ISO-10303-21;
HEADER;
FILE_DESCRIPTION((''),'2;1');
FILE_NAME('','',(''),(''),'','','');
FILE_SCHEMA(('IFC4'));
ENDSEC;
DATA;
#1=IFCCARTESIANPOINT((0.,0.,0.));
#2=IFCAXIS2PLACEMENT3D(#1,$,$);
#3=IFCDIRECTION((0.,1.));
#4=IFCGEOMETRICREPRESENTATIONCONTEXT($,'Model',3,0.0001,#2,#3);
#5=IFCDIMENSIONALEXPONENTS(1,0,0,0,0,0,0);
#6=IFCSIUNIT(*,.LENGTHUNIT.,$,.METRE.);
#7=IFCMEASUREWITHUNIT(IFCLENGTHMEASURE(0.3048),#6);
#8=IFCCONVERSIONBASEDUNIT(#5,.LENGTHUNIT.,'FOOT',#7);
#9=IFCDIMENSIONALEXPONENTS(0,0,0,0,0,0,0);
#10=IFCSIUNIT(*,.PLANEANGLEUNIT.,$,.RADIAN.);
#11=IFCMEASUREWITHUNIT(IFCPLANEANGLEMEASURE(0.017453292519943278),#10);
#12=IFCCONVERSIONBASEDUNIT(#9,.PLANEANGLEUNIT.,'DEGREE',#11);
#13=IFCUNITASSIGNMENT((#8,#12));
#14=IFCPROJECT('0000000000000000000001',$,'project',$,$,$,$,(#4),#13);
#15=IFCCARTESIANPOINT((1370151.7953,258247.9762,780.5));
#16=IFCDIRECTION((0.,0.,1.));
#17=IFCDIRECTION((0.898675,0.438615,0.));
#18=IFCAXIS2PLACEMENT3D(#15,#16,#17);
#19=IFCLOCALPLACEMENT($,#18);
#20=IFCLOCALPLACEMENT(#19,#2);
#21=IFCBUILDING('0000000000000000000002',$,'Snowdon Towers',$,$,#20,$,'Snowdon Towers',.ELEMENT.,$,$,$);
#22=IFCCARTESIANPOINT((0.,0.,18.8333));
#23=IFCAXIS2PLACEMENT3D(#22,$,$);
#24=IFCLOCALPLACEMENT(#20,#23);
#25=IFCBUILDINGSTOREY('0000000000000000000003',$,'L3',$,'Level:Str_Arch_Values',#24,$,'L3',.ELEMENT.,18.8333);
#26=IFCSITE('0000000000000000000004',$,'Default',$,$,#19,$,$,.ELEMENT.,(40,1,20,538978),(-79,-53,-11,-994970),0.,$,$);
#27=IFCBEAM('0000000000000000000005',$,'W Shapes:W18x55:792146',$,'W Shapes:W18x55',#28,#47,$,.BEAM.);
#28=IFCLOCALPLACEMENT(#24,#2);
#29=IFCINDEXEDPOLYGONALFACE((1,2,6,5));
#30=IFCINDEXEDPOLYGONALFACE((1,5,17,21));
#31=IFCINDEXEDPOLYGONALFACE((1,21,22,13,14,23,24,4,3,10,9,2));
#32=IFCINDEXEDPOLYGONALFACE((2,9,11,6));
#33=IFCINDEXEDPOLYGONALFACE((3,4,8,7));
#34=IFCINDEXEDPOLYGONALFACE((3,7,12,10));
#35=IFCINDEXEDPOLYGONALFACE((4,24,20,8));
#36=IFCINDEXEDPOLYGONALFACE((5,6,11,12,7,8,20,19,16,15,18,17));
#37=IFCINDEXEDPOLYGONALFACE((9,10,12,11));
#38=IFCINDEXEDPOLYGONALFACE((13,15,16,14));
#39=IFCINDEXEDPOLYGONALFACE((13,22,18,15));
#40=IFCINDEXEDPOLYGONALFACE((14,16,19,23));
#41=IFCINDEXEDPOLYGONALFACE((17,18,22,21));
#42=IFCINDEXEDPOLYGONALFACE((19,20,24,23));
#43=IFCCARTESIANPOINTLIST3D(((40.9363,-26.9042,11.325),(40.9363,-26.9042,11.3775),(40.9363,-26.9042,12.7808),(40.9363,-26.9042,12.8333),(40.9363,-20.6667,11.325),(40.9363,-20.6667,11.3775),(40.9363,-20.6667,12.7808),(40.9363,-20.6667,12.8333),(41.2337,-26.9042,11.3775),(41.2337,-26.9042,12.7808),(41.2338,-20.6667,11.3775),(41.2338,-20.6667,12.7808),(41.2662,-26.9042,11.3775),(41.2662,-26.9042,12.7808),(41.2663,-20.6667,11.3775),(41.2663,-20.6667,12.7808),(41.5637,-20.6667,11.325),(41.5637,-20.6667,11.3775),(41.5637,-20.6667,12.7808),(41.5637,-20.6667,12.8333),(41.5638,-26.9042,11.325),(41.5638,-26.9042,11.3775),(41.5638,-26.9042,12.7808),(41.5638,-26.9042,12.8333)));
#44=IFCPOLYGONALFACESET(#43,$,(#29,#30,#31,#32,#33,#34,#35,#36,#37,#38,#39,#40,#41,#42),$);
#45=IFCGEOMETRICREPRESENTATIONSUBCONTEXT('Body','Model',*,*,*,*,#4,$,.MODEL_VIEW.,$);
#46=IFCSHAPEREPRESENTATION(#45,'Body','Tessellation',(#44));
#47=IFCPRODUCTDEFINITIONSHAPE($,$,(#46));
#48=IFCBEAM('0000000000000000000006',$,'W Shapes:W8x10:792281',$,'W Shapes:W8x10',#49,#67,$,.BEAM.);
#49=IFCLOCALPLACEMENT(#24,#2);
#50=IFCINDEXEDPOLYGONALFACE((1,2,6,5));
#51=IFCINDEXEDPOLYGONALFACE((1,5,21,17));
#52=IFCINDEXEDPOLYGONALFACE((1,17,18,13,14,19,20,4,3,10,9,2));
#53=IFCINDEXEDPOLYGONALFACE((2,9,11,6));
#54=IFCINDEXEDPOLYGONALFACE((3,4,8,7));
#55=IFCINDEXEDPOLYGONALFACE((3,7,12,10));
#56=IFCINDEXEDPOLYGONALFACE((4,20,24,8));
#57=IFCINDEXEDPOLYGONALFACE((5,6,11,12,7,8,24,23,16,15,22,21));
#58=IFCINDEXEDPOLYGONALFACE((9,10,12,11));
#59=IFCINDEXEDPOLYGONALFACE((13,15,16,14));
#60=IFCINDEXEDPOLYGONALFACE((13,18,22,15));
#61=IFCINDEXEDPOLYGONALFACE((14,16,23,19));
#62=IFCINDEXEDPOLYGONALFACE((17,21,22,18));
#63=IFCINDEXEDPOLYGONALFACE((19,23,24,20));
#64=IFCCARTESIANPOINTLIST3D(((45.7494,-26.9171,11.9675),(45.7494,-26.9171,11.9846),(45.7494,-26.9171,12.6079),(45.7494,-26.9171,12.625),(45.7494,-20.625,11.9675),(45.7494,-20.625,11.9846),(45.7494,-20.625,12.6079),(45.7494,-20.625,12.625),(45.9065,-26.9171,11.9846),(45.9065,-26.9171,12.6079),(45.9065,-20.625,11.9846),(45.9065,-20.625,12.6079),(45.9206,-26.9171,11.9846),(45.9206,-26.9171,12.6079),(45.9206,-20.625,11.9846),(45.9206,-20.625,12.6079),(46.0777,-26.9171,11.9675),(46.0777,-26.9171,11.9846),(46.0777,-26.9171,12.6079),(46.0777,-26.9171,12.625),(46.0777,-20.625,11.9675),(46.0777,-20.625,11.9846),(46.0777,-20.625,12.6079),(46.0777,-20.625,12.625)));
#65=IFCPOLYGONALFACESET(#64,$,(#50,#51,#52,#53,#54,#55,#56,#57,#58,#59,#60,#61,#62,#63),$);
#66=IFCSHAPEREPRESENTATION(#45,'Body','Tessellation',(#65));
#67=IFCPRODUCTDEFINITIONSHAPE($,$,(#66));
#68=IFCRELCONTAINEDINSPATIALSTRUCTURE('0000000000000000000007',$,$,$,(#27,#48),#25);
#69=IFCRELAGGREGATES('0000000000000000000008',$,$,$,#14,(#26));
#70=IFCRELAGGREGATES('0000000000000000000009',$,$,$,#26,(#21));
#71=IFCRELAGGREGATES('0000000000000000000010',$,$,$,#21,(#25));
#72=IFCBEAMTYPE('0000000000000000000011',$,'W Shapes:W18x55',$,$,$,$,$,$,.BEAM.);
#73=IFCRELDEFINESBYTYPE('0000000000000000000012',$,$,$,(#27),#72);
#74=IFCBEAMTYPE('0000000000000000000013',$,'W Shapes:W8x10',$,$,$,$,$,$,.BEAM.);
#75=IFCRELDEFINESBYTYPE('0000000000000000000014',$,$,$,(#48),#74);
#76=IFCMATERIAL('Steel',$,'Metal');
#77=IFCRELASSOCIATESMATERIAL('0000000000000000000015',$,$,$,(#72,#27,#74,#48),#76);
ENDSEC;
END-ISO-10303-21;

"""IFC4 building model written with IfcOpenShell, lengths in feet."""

from ifc_helpers import new_model, entity, si_unit, converted_unit, direction, frame, origin, place, context, subcontext, project, spatial, indexed_curve, outline, extrude, source, transform, mapped, material, type_object, type_shapes, element, save


model = new_model("IFC4")

# Units and contexts
model_context = context("Model", 3, precision=0.0001, world=origin(), true_north=direction((0.0, 1.0)))
body_context = subcontext(model_context, "Body", "Model", "MODEL_VIEW")
ifc_project = project(units=[converted_unit("LENGTHUNIT", "FOOT", entity("IfcLengthMeasure", 0.3048), si_unit("LENGTHUNIT", "METRE"), dimensions=[1, 0, 0, 0, 0, 0, 0]), converted_unit("PLANEANGLEUNIT", "DEGREE", entity("IfcPlaneAngleMeasure", 0.017453292519943278), si_unit("PLANEANGLEUNIT", "RADIAN"), dimensions=[0, 0, 0, 0, 0, 0, 0])], contexts=[model_context])

# Site, building, storey
site_placement = place(None, frame((1370151.7953, 258247.9762, 780.5), z_axis=(0.0, 0.0, 1.0), x_axis=(0.898675, 0.438615, 0.0)))
site = spatial("IfcSite", under=ifc_project, at=site_placement, Name="Default", CompositionType="ELEMENT", RefLatitude=(40, 1, 20, 538978), RefLongitude=(-79, -53, -11, -994970), RefElevation=0.0)
building_placement = place(site_placement, origin())
building = spatial("IfcBuilding", under=site, at=building_placement, Name="Snowdon Towers", LongName="Snowdon Towers", CompositionType="ELEMENT")
storey_placement = place(building_placement, frame((0.0, 0.0, 18.8333)))
storey = spatial("IfcBuildingStorey", under=building, at=storey_placement, Name="L3", ObjectType="Level:Str_Arch_Values", LongName="L3", CompositionType="ELEMENT", Elevation=18.8333)

# Beam
ifc_material = material(Name="Steel", Category="Metal")
beam_type_1 = type_object("IfcBeamType", Name="W Shapes:W18x55", PredefinedType="BEAM", material=ifc_material)
shared_shape_1 = source(origin(), body_context, "Body", "SweptSolid", [
    extrude(outline(indexed_curve([(-0.3138, -0.7017), (-0.3138, -0.7542), (0.3138, -0.7542), (0.3138, -0.7017), (0.0162, -0.7017), (0.0162, 0.7017), (0.3138, 0.7017), (0.3138, 0.7542), (-0.3137, 0.7542), (-0.3137, 0.7017), (-0.0163, 0.7017), (-0.0163, -0.7017), (-0.3138, -0.7017)], self_intersect=False)), frame((-3.3958, 0.0, 0.0), z_axis=(-1.0, 0.0, 0.0), x_axis=(0.0, -1.0, 0.0)), (0.0, 0.0, -1.0), 6.2375),
])
type_shapes(beam_type_1, [shared_shape_1])
beam_1_placement = place(storey_placement, frame((41.25, -24.0625, 12.0792), z_axis=(0.0, 0.0, 1.0), x_axis=(0.0, -1.0, 0.0)))
element("IfcBeam", 1, at=beam_1_placement, inside=storey, type_object=beam_type_1, material=ifc_material, Name="W Shapes:W18x55:792146", ObjectType="W Shapes:W18x55", PredefinedType="BEAM", context=body_context, shape_type="MappedRepresentation", body=[
    mapped(shared_shape_1, transform((0.0, 0.0, 0.0), scale=1.0)),
])

# Beam
beam_type_2 = type_object("IfcBeamType", Name="W Shapes:W8x10", PredefinedType="BEAM", material=ifc_material)
shared_shape_2 = source(origin(), body_context, "Body", "SweptSolid", [
    extrude(outline(indexed_curve([(-0.1642, -0.3117), (-0.1642, -0.3288), (0.1642, -0.3288), (0.1642, -0.3117), (0.0071, -0.3117), (0.0071, 0.3117), (0.1642, 0.3117), (0.1642, 0.3287), (-0.1642, 0.3287), (-0.1642, 0.3117), (-0.0071, 0.3117), (-0.0071, -0.3117), (-0.1642, -0.3117)], self_intersect=False)), frame((-3.0585, 0.0, 0.0), z_axis=(-1.0, 0.0, 0.0), x_axis=(0.0, -1.0, 0.0)), (0.0, 0.0, -1.0), 6.2921),
])
type_shapes(beam_type_2, [shared_shape_2])
beam_2_placement = place(storey_placement, frame((45.9135, -23.6835, 12.2963), z_axis=(0.0, 0.0, 1.0), x_axis=(0.0, -1.0, 0.0)))
element("IfcBeam", 2, at=beam_2_placement, inside=storey, type_object=beam_type_2, material=ifc_material, Name="W Shapes:W8x10:792281", ObjectType="W Shapes:W8x10", PredefinedType="BEAM", context=body_context, shape_type="MappedRepresentation", body=[
    mapped(shared_shape_2, transform((0.0, 0.0, 0.0), scale=1.0)),
])

save(model, "model.ifc")
